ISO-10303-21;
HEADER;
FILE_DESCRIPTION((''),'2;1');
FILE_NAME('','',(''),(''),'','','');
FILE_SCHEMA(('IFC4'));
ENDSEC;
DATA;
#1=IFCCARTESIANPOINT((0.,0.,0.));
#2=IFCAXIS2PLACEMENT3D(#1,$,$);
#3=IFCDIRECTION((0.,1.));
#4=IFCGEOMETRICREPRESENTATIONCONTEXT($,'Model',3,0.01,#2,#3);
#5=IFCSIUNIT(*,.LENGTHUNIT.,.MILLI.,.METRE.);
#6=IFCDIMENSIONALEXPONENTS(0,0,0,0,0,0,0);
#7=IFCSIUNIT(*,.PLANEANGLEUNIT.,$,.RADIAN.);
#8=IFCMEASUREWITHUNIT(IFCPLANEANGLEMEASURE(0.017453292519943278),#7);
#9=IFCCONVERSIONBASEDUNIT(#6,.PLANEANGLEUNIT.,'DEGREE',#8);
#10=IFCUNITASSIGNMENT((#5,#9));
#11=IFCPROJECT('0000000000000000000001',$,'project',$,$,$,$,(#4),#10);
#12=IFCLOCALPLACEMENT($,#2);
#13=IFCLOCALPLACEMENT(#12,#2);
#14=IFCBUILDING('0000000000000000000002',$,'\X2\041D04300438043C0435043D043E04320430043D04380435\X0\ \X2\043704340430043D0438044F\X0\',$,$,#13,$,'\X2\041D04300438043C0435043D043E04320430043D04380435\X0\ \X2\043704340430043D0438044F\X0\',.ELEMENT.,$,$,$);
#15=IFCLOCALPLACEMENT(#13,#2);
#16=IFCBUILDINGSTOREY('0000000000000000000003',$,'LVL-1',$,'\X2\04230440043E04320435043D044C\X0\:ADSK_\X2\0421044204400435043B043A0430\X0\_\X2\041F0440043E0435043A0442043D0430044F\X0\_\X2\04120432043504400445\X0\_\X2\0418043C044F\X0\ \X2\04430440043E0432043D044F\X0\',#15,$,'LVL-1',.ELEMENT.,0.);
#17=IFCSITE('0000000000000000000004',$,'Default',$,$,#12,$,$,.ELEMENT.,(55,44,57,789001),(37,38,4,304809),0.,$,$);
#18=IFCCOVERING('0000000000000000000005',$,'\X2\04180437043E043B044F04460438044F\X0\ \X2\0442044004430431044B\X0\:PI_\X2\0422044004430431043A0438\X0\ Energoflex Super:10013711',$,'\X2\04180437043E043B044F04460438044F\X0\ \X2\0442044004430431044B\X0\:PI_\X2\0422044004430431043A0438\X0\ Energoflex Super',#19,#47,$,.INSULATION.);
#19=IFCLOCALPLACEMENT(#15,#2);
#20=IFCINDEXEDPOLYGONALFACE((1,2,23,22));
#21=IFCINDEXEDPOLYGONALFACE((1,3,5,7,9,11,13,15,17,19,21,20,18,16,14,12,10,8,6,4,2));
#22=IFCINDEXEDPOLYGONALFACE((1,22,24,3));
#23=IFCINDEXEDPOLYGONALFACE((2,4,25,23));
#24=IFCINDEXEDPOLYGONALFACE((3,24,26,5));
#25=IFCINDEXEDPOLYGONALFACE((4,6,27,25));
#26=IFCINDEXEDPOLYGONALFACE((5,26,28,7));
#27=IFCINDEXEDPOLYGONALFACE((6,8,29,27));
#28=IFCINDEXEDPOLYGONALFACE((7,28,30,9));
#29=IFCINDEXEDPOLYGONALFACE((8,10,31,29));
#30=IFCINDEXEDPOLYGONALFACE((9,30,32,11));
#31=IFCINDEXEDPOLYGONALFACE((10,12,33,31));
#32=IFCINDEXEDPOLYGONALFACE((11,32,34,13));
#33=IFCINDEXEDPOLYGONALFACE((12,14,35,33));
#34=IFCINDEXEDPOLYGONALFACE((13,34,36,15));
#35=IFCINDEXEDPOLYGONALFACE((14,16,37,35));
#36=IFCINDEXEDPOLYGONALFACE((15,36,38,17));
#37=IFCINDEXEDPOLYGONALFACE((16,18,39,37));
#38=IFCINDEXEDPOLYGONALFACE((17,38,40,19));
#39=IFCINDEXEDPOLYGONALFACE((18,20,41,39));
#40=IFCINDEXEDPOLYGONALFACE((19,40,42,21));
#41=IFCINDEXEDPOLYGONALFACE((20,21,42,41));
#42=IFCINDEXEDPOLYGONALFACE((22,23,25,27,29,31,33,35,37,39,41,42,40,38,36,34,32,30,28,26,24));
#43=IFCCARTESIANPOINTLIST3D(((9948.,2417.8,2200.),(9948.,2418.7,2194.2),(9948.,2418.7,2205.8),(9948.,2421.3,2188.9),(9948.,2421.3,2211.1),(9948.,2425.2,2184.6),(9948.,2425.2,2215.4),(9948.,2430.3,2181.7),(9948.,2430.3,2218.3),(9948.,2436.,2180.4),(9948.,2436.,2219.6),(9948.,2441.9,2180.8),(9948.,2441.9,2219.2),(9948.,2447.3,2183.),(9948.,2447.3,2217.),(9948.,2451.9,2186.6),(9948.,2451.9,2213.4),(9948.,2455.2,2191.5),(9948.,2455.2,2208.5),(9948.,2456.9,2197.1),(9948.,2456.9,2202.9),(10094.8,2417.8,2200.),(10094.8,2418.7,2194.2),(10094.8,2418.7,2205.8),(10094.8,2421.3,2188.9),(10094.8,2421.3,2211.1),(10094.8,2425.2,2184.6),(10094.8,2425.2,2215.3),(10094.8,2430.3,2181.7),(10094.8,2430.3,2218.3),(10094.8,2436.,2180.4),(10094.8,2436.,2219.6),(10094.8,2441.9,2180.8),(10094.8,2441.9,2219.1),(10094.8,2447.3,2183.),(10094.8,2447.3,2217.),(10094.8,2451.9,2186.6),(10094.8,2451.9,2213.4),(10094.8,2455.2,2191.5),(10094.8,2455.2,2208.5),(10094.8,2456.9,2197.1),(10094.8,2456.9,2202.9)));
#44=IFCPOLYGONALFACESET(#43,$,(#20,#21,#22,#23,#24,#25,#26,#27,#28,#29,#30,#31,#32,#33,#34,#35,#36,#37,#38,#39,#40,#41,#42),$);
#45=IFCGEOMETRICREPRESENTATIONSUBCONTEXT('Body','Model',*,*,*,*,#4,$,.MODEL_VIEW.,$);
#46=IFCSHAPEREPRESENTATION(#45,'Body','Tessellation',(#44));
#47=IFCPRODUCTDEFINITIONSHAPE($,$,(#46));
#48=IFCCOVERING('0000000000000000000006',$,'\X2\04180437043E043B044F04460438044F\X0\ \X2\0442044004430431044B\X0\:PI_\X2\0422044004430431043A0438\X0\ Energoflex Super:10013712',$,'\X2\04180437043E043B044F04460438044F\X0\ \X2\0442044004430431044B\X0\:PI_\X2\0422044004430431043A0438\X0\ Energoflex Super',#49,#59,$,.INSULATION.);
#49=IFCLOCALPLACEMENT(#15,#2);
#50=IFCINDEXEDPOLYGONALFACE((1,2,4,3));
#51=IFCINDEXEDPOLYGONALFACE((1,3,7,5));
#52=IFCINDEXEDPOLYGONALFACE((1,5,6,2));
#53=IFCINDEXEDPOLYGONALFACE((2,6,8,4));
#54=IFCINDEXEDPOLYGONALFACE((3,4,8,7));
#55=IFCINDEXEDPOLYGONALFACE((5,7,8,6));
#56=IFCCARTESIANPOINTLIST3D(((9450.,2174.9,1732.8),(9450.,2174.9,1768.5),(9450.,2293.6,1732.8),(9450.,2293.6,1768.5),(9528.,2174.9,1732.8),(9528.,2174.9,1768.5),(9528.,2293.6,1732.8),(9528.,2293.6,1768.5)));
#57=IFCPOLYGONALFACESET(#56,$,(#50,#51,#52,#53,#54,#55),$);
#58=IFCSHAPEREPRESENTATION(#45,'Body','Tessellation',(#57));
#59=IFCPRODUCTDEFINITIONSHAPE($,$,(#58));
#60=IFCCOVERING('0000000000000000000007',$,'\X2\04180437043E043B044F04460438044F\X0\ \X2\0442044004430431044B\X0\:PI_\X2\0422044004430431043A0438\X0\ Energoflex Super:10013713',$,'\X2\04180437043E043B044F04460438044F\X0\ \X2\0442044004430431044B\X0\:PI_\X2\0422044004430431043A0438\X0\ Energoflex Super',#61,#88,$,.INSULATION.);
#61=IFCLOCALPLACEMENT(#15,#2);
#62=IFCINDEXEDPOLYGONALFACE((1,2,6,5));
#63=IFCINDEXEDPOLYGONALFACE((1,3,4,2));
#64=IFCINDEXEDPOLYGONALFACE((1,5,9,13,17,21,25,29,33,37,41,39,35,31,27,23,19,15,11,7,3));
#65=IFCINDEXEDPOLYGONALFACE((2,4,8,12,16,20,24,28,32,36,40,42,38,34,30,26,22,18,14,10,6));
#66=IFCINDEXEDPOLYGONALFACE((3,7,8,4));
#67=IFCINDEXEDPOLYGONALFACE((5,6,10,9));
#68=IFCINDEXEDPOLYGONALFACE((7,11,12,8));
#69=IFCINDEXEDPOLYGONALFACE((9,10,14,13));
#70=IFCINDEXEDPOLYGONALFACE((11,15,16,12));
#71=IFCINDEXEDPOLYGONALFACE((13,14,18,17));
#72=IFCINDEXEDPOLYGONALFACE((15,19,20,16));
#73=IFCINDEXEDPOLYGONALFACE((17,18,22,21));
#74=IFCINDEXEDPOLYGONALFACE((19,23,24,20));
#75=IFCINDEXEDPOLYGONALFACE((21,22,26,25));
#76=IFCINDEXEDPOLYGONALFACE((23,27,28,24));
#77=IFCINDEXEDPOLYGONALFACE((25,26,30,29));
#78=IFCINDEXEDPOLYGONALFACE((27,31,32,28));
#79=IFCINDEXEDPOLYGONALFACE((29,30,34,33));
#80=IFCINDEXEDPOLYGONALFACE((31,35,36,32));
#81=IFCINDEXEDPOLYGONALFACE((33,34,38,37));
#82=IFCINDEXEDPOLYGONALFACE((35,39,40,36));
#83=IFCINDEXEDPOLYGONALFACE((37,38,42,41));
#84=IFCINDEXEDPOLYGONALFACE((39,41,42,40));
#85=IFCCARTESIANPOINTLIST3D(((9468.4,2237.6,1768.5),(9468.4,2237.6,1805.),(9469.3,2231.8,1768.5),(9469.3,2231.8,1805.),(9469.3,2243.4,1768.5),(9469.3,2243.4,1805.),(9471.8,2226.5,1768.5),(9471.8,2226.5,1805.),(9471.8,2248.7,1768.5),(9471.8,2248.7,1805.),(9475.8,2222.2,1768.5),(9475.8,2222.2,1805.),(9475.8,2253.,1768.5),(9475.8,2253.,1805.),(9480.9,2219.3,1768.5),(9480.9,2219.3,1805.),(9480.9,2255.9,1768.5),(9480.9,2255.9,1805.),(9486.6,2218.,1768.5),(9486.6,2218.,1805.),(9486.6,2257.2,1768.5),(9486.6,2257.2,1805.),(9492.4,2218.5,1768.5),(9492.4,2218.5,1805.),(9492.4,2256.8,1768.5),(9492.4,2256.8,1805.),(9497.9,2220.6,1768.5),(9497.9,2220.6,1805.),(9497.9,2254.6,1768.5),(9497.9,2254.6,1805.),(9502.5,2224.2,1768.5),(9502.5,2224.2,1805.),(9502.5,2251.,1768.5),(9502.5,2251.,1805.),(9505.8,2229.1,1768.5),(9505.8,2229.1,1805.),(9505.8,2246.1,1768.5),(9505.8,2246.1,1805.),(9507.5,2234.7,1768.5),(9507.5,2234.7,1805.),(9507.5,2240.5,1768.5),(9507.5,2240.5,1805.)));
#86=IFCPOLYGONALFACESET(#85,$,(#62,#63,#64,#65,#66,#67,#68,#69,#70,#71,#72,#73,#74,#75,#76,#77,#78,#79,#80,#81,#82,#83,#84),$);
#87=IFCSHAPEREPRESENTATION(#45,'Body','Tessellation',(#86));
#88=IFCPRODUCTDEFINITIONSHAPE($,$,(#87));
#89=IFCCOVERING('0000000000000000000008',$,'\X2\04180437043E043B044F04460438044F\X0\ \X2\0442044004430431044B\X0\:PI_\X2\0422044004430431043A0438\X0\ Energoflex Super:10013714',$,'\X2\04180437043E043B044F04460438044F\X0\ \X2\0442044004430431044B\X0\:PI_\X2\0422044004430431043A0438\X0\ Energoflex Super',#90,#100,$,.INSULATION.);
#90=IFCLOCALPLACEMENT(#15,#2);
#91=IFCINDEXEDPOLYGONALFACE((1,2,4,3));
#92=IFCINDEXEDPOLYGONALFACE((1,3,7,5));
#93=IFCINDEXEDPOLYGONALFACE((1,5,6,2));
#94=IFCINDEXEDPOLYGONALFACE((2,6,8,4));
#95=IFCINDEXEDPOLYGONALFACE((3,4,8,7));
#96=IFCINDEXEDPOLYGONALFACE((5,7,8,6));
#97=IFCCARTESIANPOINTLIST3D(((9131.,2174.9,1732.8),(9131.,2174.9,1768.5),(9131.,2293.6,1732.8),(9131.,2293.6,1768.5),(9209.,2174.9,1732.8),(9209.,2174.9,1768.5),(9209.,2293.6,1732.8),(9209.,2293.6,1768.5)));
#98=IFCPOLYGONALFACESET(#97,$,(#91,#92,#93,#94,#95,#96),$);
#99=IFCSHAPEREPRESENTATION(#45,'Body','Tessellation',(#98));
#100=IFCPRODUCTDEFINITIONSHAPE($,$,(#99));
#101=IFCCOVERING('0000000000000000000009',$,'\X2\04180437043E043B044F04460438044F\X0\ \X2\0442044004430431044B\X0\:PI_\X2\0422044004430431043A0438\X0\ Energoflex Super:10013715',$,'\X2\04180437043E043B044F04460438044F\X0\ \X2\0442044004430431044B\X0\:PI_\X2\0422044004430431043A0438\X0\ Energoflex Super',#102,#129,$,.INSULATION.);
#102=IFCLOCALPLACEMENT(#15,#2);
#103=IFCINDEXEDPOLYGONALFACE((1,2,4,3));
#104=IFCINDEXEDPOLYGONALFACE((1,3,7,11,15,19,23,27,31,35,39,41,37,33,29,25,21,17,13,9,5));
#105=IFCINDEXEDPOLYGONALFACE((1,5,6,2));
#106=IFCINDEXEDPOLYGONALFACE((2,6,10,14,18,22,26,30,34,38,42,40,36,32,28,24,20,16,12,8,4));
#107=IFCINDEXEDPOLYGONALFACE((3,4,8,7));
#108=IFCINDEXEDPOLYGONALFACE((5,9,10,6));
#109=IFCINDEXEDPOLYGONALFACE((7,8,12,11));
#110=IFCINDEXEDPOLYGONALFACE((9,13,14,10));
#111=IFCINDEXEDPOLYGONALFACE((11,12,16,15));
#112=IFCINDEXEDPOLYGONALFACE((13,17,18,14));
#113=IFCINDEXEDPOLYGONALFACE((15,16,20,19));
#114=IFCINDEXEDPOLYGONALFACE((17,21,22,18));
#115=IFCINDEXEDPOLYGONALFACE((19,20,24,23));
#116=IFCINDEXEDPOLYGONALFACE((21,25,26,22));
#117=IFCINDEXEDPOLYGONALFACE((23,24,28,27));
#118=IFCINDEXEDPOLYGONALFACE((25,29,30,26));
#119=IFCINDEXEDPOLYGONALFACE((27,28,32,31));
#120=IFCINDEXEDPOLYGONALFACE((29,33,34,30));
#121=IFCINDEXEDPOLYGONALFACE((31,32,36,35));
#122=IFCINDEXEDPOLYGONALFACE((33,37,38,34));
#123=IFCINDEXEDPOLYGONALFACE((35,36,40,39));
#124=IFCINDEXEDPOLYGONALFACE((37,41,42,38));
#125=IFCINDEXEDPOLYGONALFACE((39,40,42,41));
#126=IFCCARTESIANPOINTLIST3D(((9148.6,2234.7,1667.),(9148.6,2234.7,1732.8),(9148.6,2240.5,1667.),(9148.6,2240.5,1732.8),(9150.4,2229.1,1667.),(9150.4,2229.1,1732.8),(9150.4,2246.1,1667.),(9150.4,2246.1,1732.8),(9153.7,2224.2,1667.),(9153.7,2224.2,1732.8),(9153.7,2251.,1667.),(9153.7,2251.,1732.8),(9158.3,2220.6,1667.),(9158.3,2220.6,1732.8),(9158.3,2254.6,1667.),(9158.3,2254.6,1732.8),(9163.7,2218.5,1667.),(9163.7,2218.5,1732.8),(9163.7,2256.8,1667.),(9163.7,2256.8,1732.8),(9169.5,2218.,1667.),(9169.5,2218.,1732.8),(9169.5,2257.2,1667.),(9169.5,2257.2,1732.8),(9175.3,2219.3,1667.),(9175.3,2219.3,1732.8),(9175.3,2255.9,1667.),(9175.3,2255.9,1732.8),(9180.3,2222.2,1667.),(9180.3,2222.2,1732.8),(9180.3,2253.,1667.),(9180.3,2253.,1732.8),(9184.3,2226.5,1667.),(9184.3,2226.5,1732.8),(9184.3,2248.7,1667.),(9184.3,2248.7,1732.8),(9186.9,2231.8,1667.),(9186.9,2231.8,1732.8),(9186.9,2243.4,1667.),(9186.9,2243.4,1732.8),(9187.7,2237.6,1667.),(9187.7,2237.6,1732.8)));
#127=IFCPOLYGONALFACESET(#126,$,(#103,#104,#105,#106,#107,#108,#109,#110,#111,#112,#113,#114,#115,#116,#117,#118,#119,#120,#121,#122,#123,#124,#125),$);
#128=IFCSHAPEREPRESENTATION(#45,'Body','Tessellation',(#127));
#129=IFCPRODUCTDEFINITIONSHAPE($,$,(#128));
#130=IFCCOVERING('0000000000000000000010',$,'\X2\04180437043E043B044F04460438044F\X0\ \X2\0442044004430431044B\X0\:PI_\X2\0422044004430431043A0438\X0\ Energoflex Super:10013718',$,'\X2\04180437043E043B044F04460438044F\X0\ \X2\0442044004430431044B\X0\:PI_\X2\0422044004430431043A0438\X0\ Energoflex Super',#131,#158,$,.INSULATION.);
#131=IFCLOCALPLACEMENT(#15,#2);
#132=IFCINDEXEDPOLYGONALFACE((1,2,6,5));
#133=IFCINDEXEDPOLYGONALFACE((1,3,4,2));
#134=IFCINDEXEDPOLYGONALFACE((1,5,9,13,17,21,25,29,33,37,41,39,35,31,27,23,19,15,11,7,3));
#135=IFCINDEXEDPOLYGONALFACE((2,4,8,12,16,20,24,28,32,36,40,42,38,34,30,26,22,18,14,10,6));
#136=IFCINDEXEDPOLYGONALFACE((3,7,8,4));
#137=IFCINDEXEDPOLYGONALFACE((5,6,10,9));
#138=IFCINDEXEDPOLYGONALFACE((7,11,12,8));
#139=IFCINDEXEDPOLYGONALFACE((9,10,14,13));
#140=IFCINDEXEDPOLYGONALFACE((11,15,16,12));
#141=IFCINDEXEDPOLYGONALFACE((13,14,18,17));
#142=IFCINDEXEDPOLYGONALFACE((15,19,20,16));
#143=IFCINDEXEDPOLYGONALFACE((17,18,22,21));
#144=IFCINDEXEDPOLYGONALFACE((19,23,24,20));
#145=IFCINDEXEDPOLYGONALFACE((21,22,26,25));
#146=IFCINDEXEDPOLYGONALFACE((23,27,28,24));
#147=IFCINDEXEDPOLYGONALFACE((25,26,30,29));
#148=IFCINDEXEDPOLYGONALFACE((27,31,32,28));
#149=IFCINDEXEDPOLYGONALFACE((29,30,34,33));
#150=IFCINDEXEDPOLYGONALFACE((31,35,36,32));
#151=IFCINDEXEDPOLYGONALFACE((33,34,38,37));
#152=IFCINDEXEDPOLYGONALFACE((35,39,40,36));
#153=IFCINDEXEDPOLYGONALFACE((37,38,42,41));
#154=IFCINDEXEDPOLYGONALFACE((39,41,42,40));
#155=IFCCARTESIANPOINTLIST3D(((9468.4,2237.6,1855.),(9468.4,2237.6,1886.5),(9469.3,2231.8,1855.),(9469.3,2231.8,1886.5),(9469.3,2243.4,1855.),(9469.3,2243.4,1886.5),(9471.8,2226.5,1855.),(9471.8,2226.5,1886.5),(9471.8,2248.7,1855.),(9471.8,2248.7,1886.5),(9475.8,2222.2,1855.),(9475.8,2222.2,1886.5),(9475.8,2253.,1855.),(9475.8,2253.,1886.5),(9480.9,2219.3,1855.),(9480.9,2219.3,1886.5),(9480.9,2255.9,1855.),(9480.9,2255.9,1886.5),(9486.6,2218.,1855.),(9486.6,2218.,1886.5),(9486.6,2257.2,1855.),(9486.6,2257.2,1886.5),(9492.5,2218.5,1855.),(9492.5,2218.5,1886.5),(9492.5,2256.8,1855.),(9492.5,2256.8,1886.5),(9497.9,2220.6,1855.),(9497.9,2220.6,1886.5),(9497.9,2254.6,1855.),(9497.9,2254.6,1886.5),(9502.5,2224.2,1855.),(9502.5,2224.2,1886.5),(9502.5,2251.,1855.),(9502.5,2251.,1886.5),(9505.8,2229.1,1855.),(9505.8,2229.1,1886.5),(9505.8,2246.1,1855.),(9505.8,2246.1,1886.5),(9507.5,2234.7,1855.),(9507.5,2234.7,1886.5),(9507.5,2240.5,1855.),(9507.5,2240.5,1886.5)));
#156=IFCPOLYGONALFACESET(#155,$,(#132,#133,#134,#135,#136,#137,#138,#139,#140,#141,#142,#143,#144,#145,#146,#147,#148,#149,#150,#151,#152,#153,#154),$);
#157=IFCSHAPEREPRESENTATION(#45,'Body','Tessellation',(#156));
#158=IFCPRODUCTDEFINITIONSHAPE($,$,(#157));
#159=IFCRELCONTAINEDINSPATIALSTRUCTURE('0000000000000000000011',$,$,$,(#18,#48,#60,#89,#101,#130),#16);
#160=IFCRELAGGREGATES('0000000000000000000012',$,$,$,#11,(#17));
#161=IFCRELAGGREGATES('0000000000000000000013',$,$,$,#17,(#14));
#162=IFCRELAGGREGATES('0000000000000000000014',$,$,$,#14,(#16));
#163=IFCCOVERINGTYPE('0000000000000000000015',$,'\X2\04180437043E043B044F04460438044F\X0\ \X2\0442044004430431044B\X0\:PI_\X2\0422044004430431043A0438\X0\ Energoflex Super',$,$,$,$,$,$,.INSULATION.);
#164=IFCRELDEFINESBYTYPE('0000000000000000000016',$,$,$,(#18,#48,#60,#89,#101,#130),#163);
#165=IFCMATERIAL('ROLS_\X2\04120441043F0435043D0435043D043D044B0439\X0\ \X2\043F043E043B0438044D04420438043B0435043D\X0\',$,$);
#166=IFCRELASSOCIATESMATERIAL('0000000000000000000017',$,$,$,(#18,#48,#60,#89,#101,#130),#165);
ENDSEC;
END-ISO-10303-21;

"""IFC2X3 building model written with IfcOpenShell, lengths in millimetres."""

from ifc_helpers import new_model, entity, si_unit, converted_unit, direction, frame, frame_2d, origin, origin_2d_with_axis, place, context, subcontext, project, spatial, rectangle, circle, extrude, material, type_object, element, save


model = new_model("IFC2X3")

# Units and contexts
model_context = context("Model", 3, precision=0.01, world=origin(), true_north=direction((0.0, 1.0)))
body_context = subcontext(model_context, "Body", "Model", "MODEL_VIEW")
ifc_project = project(units=[si_unit("LENGTHUNIT", "METRE", prefix="MILLI"), converted_unit("PLANEANGLEUNIT", "DEGREE", entity("IfcPlaneAngleMeasure", 0.017453292519943278), si_unit("PLANEANGLEUNIT", "RADIAN"), dimensions=[0, 0, 0, 0, 0, 0, 0])], contexts=[model_context])

# Site, building, storey
site_placement = place(None, origin())
site = spatial("IfcSite", under=ifc_project, at=site_placement, Name="Default", CompositionType="ELEMENT", RefLatitude=(55, 44, 57, 789001), RefLongitude=(37, 38, 4, 304809), RefElevation=0.0)
building_placement = place(site_placement, origin())
building = spatial("IfcBuilding", under=site, at=building_placement, Name="Наименование здания", LongName="Наименование здания", CompositionType="ELEMENT")
storey_placement = place(building_placement, origin())
storey = spatial("IfcBuildingStorey", under=building, at=storey_placement, Name="LVL-1", ObjectType="Уровень:ADSK_Стрелка_Проектная_Вверх_Имя уровня", LongName="LVL-1", CompositionType="ELEMENT", Elevation=0.0)

# Coverings
ifc_material = material(Name="ROLS_Вспененный полиэтилен")
covering_type = type_object("IfcCoveringType", Name="Изоляция трубы:PI_Трубки Energoflex Super", PredefinedType="INSULATION")
covering_1_placement = place(storey_placement, origin())
element("IfcCovering", 1, at=covering_1_placement, inside=storey, type_object=covering_type, material=ifc_material, Name="Изоляция трубы:PI_Трубки Energoflex Super:10013711", ObjectType="Изоляция трубы:PI_Трубки Energoflex Super", PredefinedType="INSULATION", context=body_context, shape_type="SweptSolid", body=[
    extrude(circle(Radius=19.6, at=frame_2d((0.0, 0.0), x_axis=(1.0, 0.0))), frame((10094.8, 2437.5, 2200.0), z_axis=(-1.0, 0.0, 0.000089), x_axis=(0.0, -1.0, 0.0)), (0.0, 0.0, 1.0), 146.9),
])
covering_2_placement = place(storey_placement, origin())
element("IfcCovering", 2, at=covering_2_placement, inside=storey, type_object=covering_type, material=ifc_material, Name="Изоляция трубы:PI_Трубки Energoflex Super:10013712", ObjectType="Изоляция трубы:PI_Трубки Energoflex Super", PredefinedType="INSULATION", context=body_context, shape_type="SweptSolid", body=[
    extrude(rectangle(XDim=78.0, YDim=118.7, at=frame_2d((0.0, 0.0), x_axis=(1.0, 0.0))), frame((9489.0, 2234.2, 1732.8)), (0.0, 0.0, 1.0), 35.7),
])
covering_3_placement = place(storey_placement, origin())
element("IfcCovering", 3, at=covering_3_placement, inside=storey, type_object=covering_type, material=ifc_material, Name="Изоляция трубы:PI_Трубки Energoflex Super:10013713", ObjectType="Изоляция трубы:PI_Трубки Energoflex Super", PredefinedType="INSULATION", context=body_context, shape_type="SweptSolid", body=[
    extrude(circle(Radius=19.6, at=origin_2d_with_axis()), frame((9488.0, 2237.6, 1768.5), z_axis=(0.0, 0.0, 1.0), x_axis=(-1.0, 0.0, 0.0)), (0.0, 0.0, 1.0), 36.5),
])
covering_4_placement = place(storey_placement, origin())
element("IfcCovering", 4, at=covering_4_placement, inside=storey, type_object=covering_type, material=ifc_material, Name="Изоляция трубы:PI_Трубки Energoflex Super:10013714", ObjectType="Изоляция трубы:PI_Трубки Energoflex Super", PredefinedType="INSULATION", context=body_context, shape_type="SweptSolid", body=[
    extrude(rectangle(XDim=78.0, YDim=118.7, at=frame_2d((0.0, 0.0), x_axis=(1.0, 0.0))), frame((9170.0, 2234.2, 1732.8)), (0.0, 0.0, 1.0), 35.7),
])
covering_5_placement = place(storey_placement, origin())
element("IfcCovering", 5, at=covering_5_placement, inside=storey, type_object=covering_type, material=ifc_material, Name="Изоляция трубы:PI_Трубки Energoflex Super:10013715", ObjectType="Изоляция трубы:PI_Трубки Energoflex Super", PredefinedType="INSULATION", context=body_context, shape_type="SweptSolid", body=[
    extrude(circle(Radius=19.6, at=frame_2d((0.0, 0.0), x_axis=(1.0, 0.0))), frame((9168.1, 2237.6, 1667.0)), (0.0, 0.0, 1.0), 65.8),
])
covering_6_placement = place(storey_placement, origin())
element("IfcCovering", 6, at=covering_6_placement, inside=storey, type_object=covering_type, material=ifc_material, Name="Изоляция трубы:PI_Трубки Energoflex Super:10013718", ObjectType="Изоляция трубы:PI_Трубки Energoflex Super", PredefinedType="INSULATION", context=body_context, shape_type="SweptSolid", body=[
    extrude(circle(Radius=19.6, at=origin_2d_with_axis()), frame((9488.1, 2237.6, 1855.0), z_axis=(0.0, 0.0, 1.0), x_axis=(-1.0, 0.0, 0.0)), (0.0, 0.0, 1.0), 31.5),
])

save(model, "model.ifc")
